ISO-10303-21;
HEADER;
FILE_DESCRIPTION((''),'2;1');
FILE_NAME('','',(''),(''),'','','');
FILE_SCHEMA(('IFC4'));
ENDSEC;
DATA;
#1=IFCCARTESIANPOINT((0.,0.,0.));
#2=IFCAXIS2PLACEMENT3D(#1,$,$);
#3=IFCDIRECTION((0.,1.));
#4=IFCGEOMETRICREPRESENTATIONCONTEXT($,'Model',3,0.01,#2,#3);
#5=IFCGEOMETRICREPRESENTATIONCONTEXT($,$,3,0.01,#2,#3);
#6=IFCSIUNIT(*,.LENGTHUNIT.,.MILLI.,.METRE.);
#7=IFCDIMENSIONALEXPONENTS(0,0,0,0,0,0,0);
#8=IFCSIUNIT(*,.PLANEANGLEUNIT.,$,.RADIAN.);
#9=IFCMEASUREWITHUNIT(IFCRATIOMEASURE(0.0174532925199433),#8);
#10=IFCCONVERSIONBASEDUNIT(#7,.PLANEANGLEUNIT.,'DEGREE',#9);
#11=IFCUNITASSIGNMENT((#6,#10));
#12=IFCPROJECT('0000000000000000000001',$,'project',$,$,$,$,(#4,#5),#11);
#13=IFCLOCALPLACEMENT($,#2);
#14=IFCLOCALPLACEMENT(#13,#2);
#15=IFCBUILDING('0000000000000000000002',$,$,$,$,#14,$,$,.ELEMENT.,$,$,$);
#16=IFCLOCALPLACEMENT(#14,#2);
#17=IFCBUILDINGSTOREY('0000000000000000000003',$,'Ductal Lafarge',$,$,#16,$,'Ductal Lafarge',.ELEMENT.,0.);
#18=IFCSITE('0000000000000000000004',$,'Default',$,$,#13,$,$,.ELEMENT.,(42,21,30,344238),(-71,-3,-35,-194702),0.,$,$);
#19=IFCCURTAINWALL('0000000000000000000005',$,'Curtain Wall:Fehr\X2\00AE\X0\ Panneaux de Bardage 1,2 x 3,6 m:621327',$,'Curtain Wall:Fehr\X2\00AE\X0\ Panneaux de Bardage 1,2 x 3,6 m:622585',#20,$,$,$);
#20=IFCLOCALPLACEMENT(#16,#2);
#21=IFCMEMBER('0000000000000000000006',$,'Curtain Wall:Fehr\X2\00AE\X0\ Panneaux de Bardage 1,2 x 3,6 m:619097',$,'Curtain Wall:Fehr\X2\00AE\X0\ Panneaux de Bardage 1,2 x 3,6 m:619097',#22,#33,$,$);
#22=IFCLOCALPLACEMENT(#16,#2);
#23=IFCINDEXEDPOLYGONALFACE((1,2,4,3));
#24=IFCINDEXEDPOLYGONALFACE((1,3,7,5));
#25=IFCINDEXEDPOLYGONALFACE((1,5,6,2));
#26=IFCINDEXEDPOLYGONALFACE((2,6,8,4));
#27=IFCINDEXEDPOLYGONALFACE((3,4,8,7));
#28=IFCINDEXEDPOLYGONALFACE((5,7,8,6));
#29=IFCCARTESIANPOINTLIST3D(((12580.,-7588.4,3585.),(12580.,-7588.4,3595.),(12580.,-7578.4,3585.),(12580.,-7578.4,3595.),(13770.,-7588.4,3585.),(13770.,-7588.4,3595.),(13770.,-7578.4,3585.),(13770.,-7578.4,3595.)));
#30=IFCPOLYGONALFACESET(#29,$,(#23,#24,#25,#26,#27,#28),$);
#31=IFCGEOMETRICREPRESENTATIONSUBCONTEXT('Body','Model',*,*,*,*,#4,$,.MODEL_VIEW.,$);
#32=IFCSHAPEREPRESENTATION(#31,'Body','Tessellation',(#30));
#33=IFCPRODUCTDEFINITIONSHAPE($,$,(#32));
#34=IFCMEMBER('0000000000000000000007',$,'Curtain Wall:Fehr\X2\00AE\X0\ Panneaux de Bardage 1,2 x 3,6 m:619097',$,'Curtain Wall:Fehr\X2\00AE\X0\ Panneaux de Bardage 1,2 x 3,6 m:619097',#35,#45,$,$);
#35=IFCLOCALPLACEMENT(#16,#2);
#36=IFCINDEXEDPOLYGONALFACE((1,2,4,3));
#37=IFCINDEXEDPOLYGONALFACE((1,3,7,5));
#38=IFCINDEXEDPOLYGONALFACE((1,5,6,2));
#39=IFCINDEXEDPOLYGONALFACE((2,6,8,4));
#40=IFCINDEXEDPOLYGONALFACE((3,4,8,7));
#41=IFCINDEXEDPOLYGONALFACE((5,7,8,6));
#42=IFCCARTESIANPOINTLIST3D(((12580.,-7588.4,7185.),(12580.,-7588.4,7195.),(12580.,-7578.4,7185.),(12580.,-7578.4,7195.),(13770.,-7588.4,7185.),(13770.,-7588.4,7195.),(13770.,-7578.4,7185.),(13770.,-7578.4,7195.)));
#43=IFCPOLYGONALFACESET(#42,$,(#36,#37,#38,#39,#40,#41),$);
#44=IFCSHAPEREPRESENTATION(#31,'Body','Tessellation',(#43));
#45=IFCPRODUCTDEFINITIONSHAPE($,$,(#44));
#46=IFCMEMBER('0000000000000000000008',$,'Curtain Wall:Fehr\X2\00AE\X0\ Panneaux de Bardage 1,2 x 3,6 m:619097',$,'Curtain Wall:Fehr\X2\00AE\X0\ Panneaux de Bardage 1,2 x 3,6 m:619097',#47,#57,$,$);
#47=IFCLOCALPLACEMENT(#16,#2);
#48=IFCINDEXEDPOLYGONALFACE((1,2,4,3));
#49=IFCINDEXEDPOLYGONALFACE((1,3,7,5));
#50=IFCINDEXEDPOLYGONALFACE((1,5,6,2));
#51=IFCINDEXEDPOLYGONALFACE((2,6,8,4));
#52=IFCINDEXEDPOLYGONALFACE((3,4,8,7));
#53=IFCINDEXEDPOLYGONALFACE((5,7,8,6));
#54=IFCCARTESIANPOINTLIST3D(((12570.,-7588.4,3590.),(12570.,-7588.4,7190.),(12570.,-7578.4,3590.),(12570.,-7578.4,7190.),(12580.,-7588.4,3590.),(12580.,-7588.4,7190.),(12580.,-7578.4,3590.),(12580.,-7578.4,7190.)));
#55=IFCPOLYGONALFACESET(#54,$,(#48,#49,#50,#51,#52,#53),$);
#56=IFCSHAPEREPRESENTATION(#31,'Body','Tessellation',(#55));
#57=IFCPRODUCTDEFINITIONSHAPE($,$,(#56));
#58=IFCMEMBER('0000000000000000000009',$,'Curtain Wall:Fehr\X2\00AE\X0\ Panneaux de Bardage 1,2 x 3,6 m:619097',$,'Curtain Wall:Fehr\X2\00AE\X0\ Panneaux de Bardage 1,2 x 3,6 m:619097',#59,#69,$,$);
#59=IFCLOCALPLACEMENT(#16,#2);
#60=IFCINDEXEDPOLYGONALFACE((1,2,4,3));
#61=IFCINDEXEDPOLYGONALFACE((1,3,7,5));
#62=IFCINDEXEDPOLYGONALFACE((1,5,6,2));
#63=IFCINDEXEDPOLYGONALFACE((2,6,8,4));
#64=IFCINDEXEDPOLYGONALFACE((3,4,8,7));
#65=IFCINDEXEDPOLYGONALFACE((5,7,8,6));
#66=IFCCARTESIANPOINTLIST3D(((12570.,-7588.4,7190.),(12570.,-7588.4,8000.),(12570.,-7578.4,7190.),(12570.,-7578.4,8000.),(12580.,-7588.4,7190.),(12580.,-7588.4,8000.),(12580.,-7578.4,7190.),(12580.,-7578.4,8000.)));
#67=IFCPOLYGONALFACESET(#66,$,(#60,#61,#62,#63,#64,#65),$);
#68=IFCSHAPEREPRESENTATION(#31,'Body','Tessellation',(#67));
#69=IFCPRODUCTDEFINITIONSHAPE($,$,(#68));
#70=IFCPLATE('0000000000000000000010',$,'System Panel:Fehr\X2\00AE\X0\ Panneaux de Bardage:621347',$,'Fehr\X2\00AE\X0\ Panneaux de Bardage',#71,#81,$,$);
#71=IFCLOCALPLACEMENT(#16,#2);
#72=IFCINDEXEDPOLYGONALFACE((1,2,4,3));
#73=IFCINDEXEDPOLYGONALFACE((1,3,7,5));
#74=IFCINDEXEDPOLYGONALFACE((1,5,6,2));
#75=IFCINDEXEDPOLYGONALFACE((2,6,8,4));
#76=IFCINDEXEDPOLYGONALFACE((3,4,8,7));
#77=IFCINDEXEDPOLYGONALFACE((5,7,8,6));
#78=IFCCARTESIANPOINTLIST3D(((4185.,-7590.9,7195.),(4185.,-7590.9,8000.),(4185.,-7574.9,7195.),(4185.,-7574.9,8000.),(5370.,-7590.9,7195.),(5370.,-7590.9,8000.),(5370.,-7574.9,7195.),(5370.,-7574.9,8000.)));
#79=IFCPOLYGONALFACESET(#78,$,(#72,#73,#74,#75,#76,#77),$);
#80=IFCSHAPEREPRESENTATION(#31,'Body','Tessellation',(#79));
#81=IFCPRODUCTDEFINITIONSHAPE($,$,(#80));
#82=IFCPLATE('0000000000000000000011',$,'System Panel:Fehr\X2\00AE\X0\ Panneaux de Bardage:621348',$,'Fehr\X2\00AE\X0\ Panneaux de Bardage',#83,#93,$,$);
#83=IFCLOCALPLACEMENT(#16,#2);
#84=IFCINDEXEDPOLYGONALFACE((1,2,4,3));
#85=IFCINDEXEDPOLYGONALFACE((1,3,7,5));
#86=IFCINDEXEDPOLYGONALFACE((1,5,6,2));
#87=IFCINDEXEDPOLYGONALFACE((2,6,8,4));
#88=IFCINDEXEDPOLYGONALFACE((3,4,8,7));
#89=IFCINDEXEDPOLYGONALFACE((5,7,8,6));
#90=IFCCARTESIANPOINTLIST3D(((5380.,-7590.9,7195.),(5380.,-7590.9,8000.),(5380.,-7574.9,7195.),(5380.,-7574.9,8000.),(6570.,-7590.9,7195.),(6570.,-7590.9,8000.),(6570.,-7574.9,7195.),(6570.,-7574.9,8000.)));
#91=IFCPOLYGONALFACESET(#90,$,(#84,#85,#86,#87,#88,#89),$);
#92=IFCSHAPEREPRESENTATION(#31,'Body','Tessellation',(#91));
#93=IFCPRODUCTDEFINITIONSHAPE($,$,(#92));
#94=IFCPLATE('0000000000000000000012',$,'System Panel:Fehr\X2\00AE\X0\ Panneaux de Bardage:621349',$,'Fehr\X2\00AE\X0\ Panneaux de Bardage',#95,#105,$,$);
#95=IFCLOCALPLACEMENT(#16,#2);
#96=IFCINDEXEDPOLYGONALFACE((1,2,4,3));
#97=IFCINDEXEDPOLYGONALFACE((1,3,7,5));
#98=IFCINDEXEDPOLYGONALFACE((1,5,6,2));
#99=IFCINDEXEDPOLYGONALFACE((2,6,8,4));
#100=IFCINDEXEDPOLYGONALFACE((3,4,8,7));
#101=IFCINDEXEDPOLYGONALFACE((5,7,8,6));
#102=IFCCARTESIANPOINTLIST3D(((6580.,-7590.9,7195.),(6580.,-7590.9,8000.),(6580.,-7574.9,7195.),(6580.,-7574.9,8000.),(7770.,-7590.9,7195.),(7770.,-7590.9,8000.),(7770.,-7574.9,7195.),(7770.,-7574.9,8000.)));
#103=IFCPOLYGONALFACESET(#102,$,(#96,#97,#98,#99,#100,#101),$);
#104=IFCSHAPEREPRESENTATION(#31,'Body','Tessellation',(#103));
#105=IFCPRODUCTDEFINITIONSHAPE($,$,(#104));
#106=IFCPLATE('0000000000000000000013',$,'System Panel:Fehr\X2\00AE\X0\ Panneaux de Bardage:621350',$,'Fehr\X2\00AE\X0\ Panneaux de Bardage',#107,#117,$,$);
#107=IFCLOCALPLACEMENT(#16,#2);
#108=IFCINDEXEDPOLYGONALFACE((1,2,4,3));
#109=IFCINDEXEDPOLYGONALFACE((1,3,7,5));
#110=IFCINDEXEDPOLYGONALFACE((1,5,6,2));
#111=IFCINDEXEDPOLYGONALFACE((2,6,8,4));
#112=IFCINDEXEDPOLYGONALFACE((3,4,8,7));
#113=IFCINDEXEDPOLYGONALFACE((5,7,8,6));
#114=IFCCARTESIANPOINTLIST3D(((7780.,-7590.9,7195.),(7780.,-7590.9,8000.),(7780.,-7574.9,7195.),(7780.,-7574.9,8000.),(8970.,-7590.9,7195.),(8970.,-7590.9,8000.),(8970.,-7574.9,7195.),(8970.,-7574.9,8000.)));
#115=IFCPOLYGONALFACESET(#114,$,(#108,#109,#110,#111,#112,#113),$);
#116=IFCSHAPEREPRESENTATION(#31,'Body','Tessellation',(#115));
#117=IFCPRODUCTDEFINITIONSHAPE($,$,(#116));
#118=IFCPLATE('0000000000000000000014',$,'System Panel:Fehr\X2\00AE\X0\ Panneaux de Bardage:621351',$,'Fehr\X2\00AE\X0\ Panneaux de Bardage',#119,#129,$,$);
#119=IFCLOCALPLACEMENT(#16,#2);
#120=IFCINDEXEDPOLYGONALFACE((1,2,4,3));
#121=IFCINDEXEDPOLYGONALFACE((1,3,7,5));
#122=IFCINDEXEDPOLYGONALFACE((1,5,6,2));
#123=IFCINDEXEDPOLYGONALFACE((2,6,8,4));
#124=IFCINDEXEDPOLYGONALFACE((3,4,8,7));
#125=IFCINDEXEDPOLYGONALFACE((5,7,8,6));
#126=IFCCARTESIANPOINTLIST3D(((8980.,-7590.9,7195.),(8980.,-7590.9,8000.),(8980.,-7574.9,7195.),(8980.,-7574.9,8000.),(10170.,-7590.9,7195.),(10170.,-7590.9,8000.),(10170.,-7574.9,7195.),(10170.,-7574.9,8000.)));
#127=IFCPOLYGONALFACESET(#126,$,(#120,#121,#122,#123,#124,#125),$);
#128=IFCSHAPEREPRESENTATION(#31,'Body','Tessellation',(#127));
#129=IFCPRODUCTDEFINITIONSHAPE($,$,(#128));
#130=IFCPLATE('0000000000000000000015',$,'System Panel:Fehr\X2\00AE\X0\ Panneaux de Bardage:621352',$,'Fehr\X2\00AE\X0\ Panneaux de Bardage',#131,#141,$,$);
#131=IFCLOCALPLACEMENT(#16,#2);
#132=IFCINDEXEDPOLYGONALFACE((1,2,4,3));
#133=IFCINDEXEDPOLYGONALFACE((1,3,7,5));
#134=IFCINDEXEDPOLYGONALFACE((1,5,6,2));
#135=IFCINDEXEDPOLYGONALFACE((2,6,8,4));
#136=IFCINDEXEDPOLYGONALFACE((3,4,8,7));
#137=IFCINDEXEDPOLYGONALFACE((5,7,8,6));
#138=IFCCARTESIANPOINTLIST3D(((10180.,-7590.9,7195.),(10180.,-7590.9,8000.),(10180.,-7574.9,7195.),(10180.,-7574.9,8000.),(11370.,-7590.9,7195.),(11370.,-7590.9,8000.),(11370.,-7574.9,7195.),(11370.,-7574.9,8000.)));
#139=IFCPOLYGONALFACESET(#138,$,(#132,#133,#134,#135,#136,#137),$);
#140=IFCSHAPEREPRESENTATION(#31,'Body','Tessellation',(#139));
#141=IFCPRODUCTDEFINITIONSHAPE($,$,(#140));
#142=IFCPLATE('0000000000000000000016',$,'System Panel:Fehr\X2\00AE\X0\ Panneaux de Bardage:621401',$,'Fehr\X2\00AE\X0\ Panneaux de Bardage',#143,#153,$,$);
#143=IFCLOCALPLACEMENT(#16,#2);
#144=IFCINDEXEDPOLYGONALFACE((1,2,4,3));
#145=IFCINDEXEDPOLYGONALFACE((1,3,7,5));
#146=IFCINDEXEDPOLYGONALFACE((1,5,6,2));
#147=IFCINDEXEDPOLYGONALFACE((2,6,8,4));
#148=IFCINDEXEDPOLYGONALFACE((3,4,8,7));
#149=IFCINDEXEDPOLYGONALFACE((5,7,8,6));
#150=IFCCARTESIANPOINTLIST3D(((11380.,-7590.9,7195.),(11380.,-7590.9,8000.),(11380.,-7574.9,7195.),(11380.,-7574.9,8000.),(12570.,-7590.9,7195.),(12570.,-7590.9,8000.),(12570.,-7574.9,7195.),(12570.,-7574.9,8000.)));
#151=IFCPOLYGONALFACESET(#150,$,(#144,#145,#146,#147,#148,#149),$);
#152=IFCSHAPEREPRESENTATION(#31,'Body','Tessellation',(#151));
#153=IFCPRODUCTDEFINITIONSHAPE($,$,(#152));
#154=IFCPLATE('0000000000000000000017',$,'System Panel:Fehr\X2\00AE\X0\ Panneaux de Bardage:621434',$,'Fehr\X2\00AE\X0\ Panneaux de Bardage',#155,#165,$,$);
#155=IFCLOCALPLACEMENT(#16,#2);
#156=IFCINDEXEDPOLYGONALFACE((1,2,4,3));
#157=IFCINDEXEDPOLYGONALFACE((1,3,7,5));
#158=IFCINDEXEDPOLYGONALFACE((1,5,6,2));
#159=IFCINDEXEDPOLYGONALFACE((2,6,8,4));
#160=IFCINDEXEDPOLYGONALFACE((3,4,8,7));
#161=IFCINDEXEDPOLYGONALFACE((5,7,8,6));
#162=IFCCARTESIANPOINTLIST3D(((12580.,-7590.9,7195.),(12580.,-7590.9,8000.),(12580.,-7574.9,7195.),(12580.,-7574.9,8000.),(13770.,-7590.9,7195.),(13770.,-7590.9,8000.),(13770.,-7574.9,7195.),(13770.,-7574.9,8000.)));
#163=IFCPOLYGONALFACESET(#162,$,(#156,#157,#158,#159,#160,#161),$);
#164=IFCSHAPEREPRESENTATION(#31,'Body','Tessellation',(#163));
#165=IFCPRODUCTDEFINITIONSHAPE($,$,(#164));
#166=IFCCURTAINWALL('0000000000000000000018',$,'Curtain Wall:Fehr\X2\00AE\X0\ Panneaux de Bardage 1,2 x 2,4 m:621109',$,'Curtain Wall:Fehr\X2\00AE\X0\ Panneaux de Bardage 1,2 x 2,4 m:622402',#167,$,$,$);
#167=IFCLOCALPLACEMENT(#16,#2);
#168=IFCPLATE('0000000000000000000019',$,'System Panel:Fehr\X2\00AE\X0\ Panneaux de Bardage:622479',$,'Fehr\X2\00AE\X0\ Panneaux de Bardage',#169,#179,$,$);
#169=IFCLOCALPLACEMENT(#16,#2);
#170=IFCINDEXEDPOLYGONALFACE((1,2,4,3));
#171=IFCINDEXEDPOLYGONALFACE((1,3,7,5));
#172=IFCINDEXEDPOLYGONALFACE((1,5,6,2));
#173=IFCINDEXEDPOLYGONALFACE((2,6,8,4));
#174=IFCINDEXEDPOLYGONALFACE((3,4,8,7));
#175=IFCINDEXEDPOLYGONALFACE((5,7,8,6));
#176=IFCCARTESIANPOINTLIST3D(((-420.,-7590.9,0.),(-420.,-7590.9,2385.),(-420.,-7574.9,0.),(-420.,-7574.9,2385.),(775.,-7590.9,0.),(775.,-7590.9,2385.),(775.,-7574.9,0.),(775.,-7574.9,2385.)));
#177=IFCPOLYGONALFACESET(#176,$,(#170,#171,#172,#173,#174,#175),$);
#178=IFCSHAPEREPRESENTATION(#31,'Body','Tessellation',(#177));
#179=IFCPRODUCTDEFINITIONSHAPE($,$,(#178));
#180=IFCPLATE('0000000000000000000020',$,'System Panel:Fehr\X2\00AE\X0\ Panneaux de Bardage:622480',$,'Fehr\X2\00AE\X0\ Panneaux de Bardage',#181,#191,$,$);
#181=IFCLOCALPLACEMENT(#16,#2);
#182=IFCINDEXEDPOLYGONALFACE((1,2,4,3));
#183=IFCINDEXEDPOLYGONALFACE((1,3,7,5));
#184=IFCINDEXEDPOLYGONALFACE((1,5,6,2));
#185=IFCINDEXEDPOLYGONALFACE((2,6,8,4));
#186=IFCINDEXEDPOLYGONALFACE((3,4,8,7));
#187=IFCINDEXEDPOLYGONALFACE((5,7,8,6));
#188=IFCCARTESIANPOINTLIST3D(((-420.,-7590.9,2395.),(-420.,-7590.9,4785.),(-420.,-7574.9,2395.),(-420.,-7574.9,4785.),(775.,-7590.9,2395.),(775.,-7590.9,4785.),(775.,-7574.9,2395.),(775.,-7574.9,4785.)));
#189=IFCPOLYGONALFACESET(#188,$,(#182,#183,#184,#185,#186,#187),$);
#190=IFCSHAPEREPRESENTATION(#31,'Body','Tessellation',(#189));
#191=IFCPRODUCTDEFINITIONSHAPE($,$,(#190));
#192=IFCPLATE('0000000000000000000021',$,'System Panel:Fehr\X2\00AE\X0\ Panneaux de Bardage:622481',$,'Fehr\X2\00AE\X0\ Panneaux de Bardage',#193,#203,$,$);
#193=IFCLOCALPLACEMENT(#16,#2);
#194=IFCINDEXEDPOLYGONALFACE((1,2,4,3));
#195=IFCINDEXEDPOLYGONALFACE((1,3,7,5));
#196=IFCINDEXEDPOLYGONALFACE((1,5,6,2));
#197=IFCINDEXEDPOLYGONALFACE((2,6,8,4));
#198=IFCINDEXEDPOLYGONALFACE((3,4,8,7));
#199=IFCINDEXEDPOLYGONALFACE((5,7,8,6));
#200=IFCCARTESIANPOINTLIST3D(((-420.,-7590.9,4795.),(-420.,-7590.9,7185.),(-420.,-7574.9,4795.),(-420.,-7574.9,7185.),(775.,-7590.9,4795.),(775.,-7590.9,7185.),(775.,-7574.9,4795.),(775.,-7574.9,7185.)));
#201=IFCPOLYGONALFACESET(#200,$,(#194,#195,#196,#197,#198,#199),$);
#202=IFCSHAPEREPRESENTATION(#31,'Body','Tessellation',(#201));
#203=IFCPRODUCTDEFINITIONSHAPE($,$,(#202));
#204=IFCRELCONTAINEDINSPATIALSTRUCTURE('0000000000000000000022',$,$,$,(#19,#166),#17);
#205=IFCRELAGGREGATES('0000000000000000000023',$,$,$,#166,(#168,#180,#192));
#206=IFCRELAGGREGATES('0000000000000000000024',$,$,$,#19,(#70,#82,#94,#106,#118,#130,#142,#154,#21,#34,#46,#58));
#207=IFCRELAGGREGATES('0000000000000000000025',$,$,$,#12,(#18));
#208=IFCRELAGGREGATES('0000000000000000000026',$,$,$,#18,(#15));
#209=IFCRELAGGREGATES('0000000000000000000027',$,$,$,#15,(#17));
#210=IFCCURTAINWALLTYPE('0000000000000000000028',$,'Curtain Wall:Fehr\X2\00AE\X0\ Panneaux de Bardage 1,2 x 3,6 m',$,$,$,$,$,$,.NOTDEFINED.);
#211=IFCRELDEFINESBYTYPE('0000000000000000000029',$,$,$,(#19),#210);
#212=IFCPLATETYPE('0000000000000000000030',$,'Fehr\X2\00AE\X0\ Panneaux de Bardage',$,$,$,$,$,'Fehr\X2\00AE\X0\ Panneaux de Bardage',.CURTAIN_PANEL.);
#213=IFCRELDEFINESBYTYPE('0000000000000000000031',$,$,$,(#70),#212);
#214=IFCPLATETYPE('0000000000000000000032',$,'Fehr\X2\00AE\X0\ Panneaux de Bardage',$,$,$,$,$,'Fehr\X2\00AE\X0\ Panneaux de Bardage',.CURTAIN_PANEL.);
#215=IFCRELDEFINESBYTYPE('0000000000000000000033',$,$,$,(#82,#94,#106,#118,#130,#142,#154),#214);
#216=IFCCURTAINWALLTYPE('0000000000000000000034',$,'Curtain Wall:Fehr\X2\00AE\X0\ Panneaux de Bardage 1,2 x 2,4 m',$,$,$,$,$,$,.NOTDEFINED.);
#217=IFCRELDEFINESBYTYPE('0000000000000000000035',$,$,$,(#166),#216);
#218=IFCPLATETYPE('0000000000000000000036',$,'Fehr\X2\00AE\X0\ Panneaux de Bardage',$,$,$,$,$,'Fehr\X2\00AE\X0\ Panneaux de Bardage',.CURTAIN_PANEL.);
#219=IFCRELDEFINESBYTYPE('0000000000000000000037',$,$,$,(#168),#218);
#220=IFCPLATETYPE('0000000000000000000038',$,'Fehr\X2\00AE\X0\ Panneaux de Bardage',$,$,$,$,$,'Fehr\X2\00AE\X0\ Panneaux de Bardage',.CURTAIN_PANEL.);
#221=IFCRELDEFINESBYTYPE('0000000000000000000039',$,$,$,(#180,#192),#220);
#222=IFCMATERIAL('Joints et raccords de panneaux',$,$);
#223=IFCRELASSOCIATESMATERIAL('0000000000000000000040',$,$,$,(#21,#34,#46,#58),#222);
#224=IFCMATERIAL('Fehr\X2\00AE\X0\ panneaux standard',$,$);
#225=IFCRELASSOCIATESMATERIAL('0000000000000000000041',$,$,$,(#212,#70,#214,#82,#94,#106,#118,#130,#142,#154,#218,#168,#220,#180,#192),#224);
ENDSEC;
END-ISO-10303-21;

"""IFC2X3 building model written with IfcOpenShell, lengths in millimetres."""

from ifc_helpers import new_model, entity, si_unit, converted_unit, direction, frame, frame_2d, origin, origin_2d_with_axis, place, context, subcontext, project, spatial, rectangle, extrude, source, transform, mapped, material, type_object, type_shapes, element, aggregate, save


model = new_model("IFC2X3")

# Units and contexts
model_context = context("Model", 3, precision=0.01, world=origin(), true_north=direction((0.0, 1.0)))
context_of_model = context(None, 3, precision=0.01, world=origin(), true_north=direction((0.0, 1.0)))
body_context = subcontext(model_context, "Body", "Model", "MODEL_VIEW")
ifc_project = project(units=[si_unit("LENGTHUNIT", "METRE", prefix="MILLI"), converted_unit("PLANEANGLEUNIT", "DEGREE", entity("IfcRatioMeasure", 0.0174532925199433), si_unit("PLANEANGLEUNIT", "RADIAN"), dimensions=[0, 0, 0, 0, 0, 0, 0])], contexts=[model_context, context_of_model])

# Site, building, storey
site_placement = place(None, origin())
site = spatial("IfcSite", under=ifc_project, at=site_placement, Name="Default", CompositionType="ELEMENT", RefLatitude=(42, 21, 30, 344238), RefLongitude=(-71, -3, -35, -194702), RefElevation=0.0)
building_placement = place(site_placement, origin())
building = spatial("IfcBuilding", under=site, at=building_placement, CompositionType="ELEMENT")
storey_placement = place(building_placement, origin())
storey = spatial("IfcBuildingStorey", under=building, at=storey_placement, Name="Ductal Lafarge", LongName="Ductal Lafarge", CompositionType="ELEMENT", Elevation=0.0)

# Curtain wall, members, plates
curtain_wall_type_1 = type_object("IfcCurtainWallType", Name="Curtain Wall:Fehr® Panneaux de Bardage 1,2 x 3,6 m", PredefinedType="NOTDEFINED")
curtain_wall_1_placement = place(storey_placement, origin())
curtain_wall_1 = element("IfcCurtainWall", 1, at=curtain_wall_1_placement, inside=storey, type_object=curtain_wall_type_1, Name="Curtain Wall:Fehr® Panneaux de Bardage 1,2 x 3,6 m:621327", ObjectType="Curtain Wall:Fehr® Panneaux de Bardage 1,2 x 3,6 m:622585")
ifc_material_1 = material(Name="Joints et raccords de panneaux")
member_1_placement = place(curtain_wall_1_placement, frame((12580.0, -7588.4, 3585.0)))
member_1 = element("IfcMember", 2, at=member_1_placement, material=ifc_material_1, Name="Curtain Wall:Fehr® Panneaux de Bardage 1,2 x 3,6 m:619097", ObjectType="Curtain Wall:Fehr® Panneaux de Bardage 1,2 x 3,6 m:619097", context=body_context, shape_type="SweptSolid", body=[
    extrude(rectangle(XDim=1190.0, YDim=10.0, at=frame_2d((0.0, 0.0), x_axis=(1.0, 0.0))), frame((595.0, 5.0, 0.0), z_axis=(0.0, 0.0, 1.0), x_axis=(-1.0, 0.0, 0.0)), (0.0, 0.0, 1.0), 10.0),
])
member_2_placement = place(curtain_wall_1_placement, frame((12580.0, -7588.4, 7185.0)))
member_2 = element("IfcMember", 3, at=member_2_placement, material=ifc_material_1, Name="Curtain Wall:Fehr® Panneaux de Bardage 1,2 x 3,6 m:619097", ObjectType="Curtain Wall:Fehr® Panneaux de Bardage 1,2 x 3,6 m:619097", context=body_context, shape_type="SweptSolid", body=[
    extrude(rectangle(XDim=1190.0, YDim=10.0, at=frame_2d((0.0, 0.0), x_axis=(1.0, 0.0))), frame((595.0, 5.0, 0.0), z_axis=(0.0, 0.0, 1.0), x_axis=(-1.0, 0.0, 0.0)), (0.0, 0.0, 1.0), 10.0),
])
member_3_placement = place(curtain_wall_1_placement, frame((12570.0, -7588.4, 3590.0)))
member_3 = element("IfcMember", 4, at=member_3_placement, material=ifc_material_1, Name="Curtain Wall:Fehr® Panneaux de Bardage 1,2 x 3,6 m:619097", ObjectType="Curtain Wall:Fehr® Panneaux de Bardage 1,2 x 3,6 m:619097", context=body_context, shape_type="SweptSolid", body=[
    extrude(rectangle(XDim=10.0, YDim=10.0, at=frame_2d((0.0, 0.0), x_axis=(1.0, 0.0))), frame((5.0, 5.0, 0.0), z_axis=(0.0, 0.0, 1.0), x_axis=(0.0, 1.0, 0.0)), (0.0, 0.0, 1.0), 3600.0),
])
member_4_placement = place(curtain_wall_1_placement, frame((12570.0, -7588.4, 7190.0)))
member_4 = element("IfcMember", 5, at=member_4_placement, material=ifc_material_1, Name="Curtain Wall:Fehr® Panneaux de Bardage 1,2 x 3,6 m:619097", ObjectType="Curtain Wall:Fehr® Panneaux de Bardage 1,2 x 3,6 m:619097", context=body_context, shape_type="SweptSolid", body=[
    extrude(rectangle(XDim=10.0, YDim=10.0, at=frame_2d((0.0, 0.0), x_axis=(1.0, 0.0))), frame((5.0, 5.0, 0.0), z_axis=(0.0, 0.0, 1.0), x_axis=(0.0, 1.0, 0.0)), (0.0, 0.0, 1.0), 810.0),
])
ifc_material_2 = material(Name="Fehr® panneaux standard")
plate_type_1 = type_object("IfcPlateType", Name="Fehr® Panneaux de Bardage", ElementType="Fehr® Panneaux de Bardage", PredefinedType="CURTAIN_PANEL", material=ifc_material_2)
shared_shape_1 = source(origin(), body_context, "Body", "SweptSolid", [
    extrude(rectangle(XDim=16.0, YDim=1185.0, at=origin_2d_with_axis()), frame((0.0, 0.0, 0.0), z_axis=(0.0, 0.0, 1.0), x_axis=(0.0, 1.0, 0.0)), (0.0, 0.0, 1.0), 805.0),
])
type_shapes(plate_type_1, [shared_shape_1])
plate_1_placement = place(curtain_wall_1_placement, frame((4777.5, -7582.9, 7195.0)))
plate_1 = element("IfcPlate", 6, at=plate_1_placement, type_object=plate_type_1, material=ifc_material_2, Name="System Panel:Fehr® Panneaux de Bardage:621347", ObjectType="Fehr® Panneaux de Bardage", context=body_context, shape_type="MappedRepresentation", body=[
    mapped(shared_shape_1, transform((0.0, 0.0, 0.0), scale=1.0)),
])
plate_type_2 = type_object("IfcPlateType", Name="Fehr® Panneaux de Bardage", ElementType="Fehr® Panneaux de Bardage", PredefinedType="CURTAIN_PANEL", material=ifc_material_2)
shared_shape_2 = source(origin(), body_context, "Body", "SweptSolid", [
    extrude(rectangle(XDim=16.0, YDim=1190.0, at=origin_2d_with_axis()), frame((0.0, 0.0, 0.0), z_axis=(0.0, 0.0, 1.0), x_axis=(0.0, 1.0, 0.0)), (0.0, 0.0, 1.0), 805.0),
])
type_shapes(plate_type_2, [shared_shape_2])
plate_2_placement = place(curtain_wall_1_placement, frame((5975.0, -7582.9, 7195.0)))
plate_2 = element("IfcPlate", 7, at=plate_2_placement, type_object=plate_type_2, material=ifc_material_2, Name="System Panel:Fehr® Panneaux de Bardage:621348", ObjectType="Fehr® Panneaux de Bardage", context=body_context, shape_type="MappedRepresentation", body=[
    mapped(shared_shape_2, transform((0.0, 0.0, 0.0), scale=1.0)),
])
plate_3_placement = place(curtain_wall_1_placement, frame((7175.0, -7582.9, 7195.0)))
plate_3 = element("IfcPlate", 8, at=plate_3_placement, type_object=plate_type_2, material=ifc_material_2, Name="System Panel:Fehr® Panneaux de Bardage:621349", ObjectType="Fehr® Panneaux de Bardage", context=body_context, shape_type="MappedRepresentation", body=[
    mapped(shared_shape_2, transform((0.0, 0.0, 0.0), scale=1.0)),
])
plate_4_placement = place(curtain_wall_1_placement, frame((8375.0, -7582.9, 7195.0)))
plate_4 = element("IfcPlate", 9, at=plate_4_placement, type_object=plate_type_2, material=ifc_material_2, Name="System Panel:Fehr® Panneaux de Bardage:621350", ObjectType="Fehr® Panneaux de Bardage", context=body_context, shape_type="MappedRepresentation", body=[
    mapped(shared_shape_2, transform((0.0, 0.0, 0.0), scale=1.0)),
])
plate_5_placement = place(curtain_wall_1_placement, frame((9575.0, -7582.9, 7195.0)))
plate_5 = element("IfcPlate", 10, at=plate_5_placement, type_object=plate_type_2, material=ifc_material_2, Name="System Panel:Fehr® Panneaux de Bardage:621351", ObjectType="Fehr® Panneaux de Bardage", context=body_context, shape_type="MappedRepresentation", body=[
    mapped(shared_shape_2, transform((0.0, 0.0, 0.0), scale=1.0)),
])
plate_6_placement = place(curtain_wall_1_placement, frame((10775.0, -7582.9, 7195.0)))
plate_6 = element("IfcPlate", 11, at=plate_6_placement, type_object=plate_type_2, material=ifc_material_2, Name="System Panel:Fehr® Panneaux de Bardage:621352", ObjectType="Fehr® Panneaux de Bardage", context=body_context, shape_type="MappedRepresentation", body=[
    mapped(shared_shape_2, transform((0.0, 0.0, 0.0), scale=1.0)),
])
plate_7_placement = place(curtain_wall_1_placement, frame((11975.0, -7582.9, 7195.0)))
plate_7 = element("IfcPlate", 12, at=plate_7_placement, type_object=plate_type_2, material=ifc_material_2, Name="System Panel:Fehr® Panneaux de Bardage:621401", ObjectType="Fehr® Panneaux de Bardage", context=body_context, shape_type="MappedRepresentation", body=[
    mapped(shared_shape_2, transform((0.0, 0.0, 0.0), scale=1.0)),
])
plate_8_placement = place(curtain_wall_1_placement, frame((13175.0, -7582.9, 7195.0)))
plate_8 = element("IfcPlate", 13, at=plate_8_placement, type_object=plate_type_2, material=ifc_material_2, Name="System Panel:Fehr® Panneaux de Bardage:621434", ObjectType="Fehr® Panneaux de Bardage", context=body_context, shape_type="MappedRepresentation", body=[
    mapped(shared_shape_2, transform((0.0, 0.0, 0.0), scale=1.0)),
])

# Curtain wall, plates
curtain_wall_type_2 = type_object("IfcCurtainWallType", Name="Curtain Wall:Fehr® Panneaux de Bardage 1,2 x 2,4 m", PredefinedType="NOTDEFINED")
curtain_wall_2_placement = place(storey_placement, origin())
curtain_wall_2 = element("IfcCurtainWall", 14, at=curtain_wall_2_placement, inside=storey, type_object=curtain_wall_type_2, Name="Curtain Wall:Fehr® Panneaux de Bardage 1,2 x 2,4 m:621109", ObjectType="Curtain Wall:Fehr® Panneaux de Bardage 1,2 x 2,4 m:622402")
plate_type_3 = type_object("IfcPlateType", Name="Fehr® Panneaux de Bardage", ElementType="Fehr® Panneaux de Bardage", PredefinedType="CURTAIN_PANEL", material=ifc_material_2)
shared_shape_3 = source(origin(), body_context, "Body", "SweptSolid", [
    extrude(rectangle(XDim=16.0, YDim=1195.0, at=origin_2d_with_axis()), frame((0.0, 0.0, 0.0), z_axis=(0.0, 0.0, 1.0), x_axis=(0.0, 1.0, 0.0)), (0.0, 0.0, 1.0), 2385.0),
])
type_shapes(plate_type_3, [shared_shape_3])
plate_9_placement = place(curtain_wall_2_placement, frame((177.5, -7582.9, 0.0)))
plate_9 = element("IfcPlate", 15, at=plate_9_placement, type_object=plate_type_3, material=ifc_material_2, Name="System Panel:Fehr® Panneaux de Bardage:622479", ObjectType="Fehr® Panneaux de Bardage", context=body_context, shape_type="MappedRepresentation", body=[
    mapped(shared_shape_3, transform((0.0, 0.0, 0.0), scale=1.0)),
])
plate_type_4 = type_object("IfcPlateType", Name="Fehr® Panneaux de Bardage", ElementType="Fehr® Panneaux de Bardage", PredefinedType="CURTAIN_PANEL", material=ifc_material_2)
shared_shape_4 = source(origin(), body_context, "Body", "SweptSolid", [
    extrude(rectangle(XDim=16.0, YDim=1195.0, at=origin_2d_with_axis()), frame((0.0, 0.0, 0.0), z_axis=(0.0, 0.0, 1.0), x_axis=(0.0, 1.0, 0.0)), (0.0, 0.0, 1.0), 2390.0),
])
type_shapes(plate_type_4, [shared_shape_4])
plate_10_placement = place(curtain_wall_2_placement, frame((177.5, -7582.9, 2395.0)))
plate_10 = element("IfcPlate", 16, at=plate_10_placement, type_object=plate_type_4, material=ifc_material_2, Name="System Panel:Fehr® Panneaux de Bardage:622480", ObjectType="Fehr® Panneaux de Bardage", context=body_context, shape_type="MappedRepresentation", body=[
    mapped(shared_shape_4, transform((0.0, 0.0, 0.0), scale=1.0)),
])
plate_11_placement = place(curtain_wall_2_placement, frame((177.5, -7582.9, 4795.0)))
plate_11 = element("IfcPlate", 17, at=plate_11_placement, type_object=plate_type_4, material=ifc_material_2, Name="System Panel:Fehr® Panneaux de Bardage:622481", ObjectType="Fehr® Panneaux de Bardage", context=body_context, shape_type="MappedRepresentation", body=[
    mapped(shared_shape_4, transform((0.0, 0.0, 0.0), scale=1.0)),
])
aggregate(curtain_wall_2, [plate_9, plate_10, plate_11])

aggregate(curtain_wall_1, [plate_1, plate_2, plate_3, plate_4, plate_5, plate_6, plate_7, plate_8, member_1, member_2, member_3, member_4])

save(model, "model.ifc")
